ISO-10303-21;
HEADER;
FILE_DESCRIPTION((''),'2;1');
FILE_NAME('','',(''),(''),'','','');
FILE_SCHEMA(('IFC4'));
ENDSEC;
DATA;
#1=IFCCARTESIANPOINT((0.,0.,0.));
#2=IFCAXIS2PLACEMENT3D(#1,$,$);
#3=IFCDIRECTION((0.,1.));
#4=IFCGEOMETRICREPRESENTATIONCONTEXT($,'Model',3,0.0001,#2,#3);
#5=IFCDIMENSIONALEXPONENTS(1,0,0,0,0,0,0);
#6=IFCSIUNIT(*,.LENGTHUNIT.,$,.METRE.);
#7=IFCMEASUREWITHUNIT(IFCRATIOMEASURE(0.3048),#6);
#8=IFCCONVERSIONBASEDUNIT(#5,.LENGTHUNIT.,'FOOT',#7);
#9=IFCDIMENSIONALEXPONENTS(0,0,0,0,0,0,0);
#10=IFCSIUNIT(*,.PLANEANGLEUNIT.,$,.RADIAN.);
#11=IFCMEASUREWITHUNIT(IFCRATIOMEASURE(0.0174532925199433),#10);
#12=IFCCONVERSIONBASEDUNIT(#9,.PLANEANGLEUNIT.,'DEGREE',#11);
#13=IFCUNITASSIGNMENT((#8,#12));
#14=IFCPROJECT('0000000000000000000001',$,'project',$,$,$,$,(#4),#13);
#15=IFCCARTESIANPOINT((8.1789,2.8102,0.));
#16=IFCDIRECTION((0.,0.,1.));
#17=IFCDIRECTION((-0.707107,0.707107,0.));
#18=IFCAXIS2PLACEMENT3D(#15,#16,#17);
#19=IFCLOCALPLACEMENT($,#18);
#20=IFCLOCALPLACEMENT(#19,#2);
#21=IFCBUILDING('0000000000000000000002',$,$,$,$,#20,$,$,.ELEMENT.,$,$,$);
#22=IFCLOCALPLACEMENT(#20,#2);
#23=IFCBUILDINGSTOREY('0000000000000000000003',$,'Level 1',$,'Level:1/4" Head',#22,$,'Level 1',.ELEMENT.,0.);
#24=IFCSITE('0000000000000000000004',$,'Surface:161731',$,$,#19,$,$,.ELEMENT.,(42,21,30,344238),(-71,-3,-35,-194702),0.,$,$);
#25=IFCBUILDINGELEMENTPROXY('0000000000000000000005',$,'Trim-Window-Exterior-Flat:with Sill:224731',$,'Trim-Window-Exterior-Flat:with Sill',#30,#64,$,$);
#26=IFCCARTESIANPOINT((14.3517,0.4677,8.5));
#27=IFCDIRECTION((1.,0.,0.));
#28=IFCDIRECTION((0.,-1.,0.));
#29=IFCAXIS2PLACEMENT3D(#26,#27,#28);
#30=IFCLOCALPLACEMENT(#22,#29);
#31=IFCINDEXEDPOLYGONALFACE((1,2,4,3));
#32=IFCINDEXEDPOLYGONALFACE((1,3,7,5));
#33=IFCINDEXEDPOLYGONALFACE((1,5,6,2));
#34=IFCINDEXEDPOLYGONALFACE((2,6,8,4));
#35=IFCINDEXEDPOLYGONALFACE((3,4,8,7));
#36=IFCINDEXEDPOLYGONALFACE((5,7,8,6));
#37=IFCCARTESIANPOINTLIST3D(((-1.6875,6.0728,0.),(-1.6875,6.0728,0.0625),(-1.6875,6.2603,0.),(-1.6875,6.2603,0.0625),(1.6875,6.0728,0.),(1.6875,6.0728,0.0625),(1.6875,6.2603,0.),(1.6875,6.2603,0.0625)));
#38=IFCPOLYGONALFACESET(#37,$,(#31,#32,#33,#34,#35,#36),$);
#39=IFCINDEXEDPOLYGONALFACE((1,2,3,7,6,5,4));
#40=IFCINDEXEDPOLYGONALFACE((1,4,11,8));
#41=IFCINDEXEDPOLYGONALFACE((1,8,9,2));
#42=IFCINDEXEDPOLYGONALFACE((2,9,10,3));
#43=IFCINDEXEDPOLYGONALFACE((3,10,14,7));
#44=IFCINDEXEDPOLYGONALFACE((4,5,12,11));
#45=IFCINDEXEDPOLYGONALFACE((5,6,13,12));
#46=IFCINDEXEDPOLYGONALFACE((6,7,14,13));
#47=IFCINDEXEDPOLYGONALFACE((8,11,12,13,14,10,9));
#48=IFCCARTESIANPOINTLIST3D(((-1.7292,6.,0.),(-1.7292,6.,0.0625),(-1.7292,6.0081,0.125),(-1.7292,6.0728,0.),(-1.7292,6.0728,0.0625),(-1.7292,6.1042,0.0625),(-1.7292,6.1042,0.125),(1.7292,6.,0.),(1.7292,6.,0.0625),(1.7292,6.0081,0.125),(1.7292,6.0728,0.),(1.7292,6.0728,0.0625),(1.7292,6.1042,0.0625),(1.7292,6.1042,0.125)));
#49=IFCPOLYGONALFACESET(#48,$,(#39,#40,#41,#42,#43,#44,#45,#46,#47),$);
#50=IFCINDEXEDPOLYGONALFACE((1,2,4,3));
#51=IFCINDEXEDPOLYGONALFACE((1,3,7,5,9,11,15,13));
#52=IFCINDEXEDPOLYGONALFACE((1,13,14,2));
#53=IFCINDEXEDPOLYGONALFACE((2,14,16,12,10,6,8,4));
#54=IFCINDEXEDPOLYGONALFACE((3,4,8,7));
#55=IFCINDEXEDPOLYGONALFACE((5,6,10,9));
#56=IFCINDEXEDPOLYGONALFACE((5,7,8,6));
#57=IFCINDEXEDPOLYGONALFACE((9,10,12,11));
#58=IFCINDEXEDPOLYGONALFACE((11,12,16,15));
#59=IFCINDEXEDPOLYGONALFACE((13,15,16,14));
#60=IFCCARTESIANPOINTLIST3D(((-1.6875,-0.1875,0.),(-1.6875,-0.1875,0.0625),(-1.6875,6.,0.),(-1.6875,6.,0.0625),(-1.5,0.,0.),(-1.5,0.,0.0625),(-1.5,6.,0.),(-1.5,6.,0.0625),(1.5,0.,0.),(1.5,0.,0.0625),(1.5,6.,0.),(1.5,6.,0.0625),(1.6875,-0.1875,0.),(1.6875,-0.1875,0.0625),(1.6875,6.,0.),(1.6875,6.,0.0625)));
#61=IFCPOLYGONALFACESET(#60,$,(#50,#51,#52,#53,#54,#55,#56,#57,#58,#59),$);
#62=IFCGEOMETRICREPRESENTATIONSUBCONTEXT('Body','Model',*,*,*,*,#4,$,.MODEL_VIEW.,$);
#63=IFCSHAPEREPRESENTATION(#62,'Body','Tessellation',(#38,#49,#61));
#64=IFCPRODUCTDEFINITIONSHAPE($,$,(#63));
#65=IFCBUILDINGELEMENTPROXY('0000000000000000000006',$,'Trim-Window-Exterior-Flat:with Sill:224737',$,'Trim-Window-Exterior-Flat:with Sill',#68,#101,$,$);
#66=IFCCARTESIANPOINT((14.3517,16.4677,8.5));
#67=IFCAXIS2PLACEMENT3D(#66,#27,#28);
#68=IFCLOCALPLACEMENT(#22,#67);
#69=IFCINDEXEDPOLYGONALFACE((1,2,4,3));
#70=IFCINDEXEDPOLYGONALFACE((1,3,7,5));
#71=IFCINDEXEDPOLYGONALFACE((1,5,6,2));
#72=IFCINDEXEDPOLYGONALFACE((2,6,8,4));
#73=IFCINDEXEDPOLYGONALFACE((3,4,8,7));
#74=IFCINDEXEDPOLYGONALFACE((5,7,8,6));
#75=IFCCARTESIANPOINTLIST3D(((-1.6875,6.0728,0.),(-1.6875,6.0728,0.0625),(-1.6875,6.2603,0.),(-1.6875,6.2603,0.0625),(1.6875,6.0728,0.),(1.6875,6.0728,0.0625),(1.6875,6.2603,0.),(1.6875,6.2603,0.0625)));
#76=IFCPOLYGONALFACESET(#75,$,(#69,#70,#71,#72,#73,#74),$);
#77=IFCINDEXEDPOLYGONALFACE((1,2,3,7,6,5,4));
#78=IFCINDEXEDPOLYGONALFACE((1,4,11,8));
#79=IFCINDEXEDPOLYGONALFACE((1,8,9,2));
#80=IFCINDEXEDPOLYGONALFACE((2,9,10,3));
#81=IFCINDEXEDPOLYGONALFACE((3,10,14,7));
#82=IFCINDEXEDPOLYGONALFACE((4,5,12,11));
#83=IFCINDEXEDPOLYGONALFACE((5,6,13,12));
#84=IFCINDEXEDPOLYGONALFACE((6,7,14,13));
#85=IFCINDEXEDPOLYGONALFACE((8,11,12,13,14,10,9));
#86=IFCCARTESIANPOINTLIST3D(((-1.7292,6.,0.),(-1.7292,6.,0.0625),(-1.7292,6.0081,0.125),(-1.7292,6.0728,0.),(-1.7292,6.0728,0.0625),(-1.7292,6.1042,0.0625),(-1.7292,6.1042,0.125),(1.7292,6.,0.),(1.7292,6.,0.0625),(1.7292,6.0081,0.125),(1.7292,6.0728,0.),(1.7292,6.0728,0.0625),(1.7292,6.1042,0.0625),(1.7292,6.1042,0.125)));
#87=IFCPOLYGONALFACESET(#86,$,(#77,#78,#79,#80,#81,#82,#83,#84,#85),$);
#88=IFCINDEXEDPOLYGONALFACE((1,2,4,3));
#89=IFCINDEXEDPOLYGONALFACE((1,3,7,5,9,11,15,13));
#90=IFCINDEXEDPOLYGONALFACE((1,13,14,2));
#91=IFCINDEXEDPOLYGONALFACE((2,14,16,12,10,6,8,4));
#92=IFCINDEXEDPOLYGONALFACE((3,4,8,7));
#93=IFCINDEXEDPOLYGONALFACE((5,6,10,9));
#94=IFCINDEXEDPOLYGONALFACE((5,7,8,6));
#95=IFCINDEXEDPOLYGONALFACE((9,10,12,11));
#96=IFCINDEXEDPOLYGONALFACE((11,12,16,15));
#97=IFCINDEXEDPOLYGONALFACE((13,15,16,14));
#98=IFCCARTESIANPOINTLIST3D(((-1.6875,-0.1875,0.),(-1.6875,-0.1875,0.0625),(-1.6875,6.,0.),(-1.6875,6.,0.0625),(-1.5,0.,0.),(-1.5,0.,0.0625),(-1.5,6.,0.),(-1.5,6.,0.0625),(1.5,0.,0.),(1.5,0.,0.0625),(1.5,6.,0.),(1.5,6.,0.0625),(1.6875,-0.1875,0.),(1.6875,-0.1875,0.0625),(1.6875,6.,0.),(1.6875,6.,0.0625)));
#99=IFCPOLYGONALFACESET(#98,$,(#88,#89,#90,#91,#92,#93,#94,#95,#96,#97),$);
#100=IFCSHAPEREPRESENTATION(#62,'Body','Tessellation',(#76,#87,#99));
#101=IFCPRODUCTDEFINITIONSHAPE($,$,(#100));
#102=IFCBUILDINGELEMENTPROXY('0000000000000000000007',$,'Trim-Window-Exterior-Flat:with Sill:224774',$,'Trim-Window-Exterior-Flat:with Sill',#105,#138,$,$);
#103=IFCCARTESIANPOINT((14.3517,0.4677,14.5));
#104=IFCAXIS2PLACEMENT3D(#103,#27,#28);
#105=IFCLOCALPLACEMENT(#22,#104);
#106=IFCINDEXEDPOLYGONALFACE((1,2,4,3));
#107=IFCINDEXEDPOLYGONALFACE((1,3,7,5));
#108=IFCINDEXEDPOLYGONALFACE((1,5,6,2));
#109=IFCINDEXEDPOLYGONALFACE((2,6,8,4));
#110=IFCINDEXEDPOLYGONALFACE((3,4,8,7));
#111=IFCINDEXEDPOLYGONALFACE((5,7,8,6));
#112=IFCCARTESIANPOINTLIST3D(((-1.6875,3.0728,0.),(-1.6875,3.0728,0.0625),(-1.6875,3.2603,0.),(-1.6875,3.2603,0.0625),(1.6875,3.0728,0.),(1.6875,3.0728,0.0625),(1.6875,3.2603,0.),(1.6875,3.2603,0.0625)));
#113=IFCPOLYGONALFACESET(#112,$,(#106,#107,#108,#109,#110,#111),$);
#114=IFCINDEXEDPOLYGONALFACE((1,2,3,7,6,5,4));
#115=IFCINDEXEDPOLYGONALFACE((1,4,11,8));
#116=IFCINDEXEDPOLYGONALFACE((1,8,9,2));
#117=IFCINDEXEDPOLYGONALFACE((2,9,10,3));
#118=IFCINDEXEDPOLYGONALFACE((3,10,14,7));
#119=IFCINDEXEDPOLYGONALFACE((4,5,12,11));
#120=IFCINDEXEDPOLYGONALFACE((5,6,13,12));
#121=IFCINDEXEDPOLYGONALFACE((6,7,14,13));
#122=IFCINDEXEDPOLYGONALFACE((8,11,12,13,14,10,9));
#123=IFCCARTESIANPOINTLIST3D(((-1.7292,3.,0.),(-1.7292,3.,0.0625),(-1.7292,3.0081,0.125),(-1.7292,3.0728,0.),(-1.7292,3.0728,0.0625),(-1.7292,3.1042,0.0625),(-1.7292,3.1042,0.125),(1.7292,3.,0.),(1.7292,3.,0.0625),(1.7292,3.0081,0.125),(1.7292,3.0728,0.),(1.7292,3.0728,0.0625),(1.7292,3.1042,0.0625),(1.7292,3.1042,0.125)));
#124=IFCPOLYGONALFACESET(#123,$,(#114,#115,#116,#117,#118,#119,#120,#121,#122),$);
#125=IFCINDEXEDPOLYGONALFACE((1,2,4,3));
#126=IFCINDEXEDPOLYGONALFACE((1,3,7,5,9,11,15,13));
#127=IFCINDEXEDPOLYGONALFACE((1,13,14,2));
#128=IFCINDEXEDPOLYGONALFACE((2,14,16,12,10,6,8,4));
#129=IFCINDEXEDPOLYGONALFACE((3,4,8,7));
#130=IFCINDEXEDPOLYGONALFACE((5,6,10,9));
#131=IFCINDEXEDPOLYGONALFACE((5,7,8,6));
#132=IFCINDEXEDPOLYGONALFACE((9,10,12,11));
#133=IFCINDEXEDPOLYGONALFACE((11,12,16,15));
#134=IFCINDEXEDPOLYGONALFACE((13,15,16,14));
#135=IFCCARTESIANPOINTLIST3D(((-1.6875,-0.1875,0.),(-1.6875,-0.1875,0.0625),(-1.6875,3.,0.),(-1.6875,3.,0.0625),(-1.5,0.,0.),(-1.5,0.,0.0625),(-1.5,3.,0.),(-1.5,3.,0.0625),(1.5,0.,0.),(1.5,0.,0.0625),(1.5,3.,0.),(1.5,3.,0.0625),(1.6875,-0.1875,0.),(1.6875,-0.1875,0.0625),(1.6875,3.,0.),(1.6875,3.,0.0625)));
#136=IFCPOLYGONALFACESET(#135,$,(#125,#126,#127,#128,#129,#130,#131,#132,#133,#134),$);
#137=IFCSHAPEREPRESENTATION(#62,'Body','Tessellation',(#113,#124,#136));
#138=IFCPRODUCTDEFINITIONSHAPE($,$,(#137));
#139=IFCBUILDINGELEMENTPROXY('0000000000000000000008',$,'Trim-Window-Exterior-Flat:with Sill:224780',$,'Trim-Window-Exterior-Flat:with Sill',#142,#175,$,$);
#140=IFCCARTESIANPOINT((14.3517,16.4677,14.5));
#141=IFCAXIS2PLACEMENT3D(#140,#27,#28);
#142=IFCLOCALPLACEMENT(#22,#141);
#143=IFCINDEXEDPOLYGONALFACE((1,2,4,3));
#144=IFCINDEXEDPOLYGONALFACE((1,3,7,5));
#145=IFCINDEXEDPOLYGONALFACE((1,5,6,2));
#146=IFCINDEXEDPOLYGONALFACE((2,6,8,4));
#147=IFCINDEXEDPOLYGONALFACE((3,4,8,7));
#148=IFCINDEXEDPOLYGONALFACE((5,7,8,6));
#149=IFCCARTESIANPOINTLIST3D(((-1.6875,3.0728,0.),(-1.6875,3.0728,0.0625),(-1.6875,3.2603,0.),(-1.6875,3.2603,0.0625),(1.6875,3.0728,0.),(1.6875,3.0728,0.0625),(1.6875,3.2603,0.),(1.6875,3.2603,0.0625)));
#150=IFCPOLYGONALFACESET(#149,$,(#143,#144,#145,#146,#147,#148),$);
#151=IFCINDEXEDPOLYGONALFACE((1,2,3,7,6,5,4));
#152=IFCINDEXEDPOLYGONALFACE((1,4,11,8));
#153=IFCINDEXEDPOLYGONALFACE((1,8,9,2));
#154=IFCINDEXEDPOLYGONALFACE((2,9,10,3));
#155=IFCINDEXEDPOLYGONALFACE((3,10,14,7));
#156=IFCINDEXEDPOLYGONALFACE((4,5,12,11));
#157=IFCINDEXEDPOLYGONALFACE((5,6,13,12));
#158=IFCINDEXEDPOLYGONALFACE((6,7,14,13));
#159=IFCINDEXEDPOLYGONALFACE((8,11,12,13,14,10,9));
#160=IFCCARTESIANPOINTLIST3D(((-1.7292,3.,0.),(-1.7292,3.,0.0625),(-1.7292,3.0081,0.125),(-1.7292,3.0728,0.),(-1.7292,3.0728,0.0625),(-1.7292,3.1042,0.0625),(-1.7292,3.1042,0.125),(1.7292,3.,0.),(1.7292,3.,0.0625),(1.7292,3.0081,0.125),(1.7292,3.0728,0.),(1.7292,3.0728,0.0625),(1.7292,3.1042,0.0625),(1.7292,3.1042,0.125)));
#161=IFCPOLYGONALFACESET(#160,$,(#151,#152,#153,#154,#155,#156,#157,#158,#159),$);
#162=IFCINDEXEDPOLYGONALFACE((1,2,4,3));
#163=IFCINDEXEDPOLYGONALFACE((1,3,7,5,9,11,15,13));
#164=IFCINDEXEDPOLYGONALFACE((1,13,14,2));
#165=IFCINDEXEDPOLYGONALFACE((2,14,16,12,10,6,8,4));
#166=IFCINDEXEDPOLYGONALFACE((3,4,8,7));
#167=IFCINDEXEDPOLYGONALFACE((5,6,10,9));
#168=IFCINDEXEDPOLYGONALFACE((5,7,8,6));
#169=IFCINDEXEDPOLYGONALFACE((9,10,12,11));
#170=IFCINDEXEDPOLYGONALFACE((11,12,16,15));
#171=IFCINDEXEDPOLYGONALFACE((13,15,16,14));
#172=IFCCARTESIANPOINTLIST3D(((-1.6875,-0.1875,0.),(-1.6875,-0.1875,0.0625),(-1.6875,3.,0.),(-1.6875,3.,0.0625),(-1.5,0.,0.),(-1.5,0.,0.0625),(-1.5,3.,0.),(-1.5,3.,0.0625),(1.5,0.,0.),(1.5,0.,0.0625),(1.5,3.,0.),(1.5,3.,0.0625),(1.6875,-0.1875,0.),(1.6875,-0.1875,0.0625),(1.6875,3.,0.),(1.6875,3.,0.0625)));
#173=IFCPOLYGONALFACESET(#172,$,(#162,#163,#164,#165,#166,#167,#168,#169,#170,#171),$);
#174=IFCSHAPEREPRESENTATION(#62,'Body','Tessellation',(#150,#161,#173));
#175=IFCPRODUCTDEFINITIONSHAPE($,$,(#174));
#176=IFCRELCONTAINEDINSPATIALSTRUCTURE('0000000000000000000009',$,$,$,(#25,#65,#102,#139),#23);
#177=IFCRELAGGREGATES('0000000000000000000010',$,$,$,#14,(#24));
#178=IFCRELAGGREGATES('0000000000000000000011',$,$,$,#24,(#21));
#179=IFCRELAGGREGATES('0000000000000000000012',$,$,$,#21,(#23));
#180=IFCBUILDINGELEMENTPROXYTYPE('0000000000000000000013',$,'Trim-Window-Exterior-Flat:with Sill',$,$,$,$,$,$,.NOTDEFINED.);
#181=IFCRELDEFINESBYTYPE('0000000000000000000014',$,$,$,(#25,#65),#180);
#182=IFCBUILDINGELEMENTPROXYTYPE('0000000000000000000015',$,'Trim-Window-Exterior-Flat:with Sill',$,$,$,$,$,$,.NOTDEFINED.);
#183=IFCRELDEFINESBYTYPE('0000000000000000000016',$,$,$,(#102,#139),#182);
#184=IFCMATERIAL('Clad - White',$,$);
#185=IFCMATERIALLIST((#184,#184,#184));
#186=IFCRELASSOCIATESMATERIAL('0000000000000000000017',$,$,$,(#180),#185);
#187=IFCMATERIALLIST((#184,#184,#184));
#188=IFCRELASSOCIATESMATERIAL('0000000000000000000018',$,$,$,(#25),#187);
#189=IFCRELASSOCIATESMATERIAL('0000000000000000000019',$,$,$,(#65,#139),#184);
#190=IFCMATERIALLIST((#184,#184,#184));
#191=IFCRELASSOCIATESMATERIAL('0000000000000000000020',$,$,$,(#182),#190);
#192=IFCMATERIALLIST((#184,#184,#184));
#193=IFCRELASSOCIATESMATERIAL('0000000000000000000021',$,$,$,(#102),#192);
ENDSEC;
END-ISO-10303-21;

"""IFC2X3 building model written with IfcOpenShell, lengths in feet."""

from ifc_helpers import new_model, entity, si_unit, converted_unit, direction, frame, frame_2d, origin, origin_2d_with_axis, place, context, subcontext, project, spatial, polyline, rectangle, outline, extrude, source, transform, mapped, material, material_list, type_object, type_shapes, element, save


model = new_model("IFC2X3")

# Units and contexts
model_context = context("Model", 3, precision=0.0001, world=origin(), true_north=direction((0.0, 1.0)))
body_context = subcontext(model_context, "Body", "Model", "MODEL_VIEW")
ifc_project = project(units=[converted_unit("LENGTHUNIT", "FOOT", entity("IfcRatioMeasure", 0.3048), si_unit("LENGTHUNIT", "METRE"), dimensions=[1, 0, 0, 0, 0, 0, 0]), converted_unit("PLANEANGLEUNIT", "DEGREE", entity("IfcRatioMeasure", 0.0174532925199433), si_unit("PLANEANGLEUNIT", "RADIAN"), dimensions=[0, 0, 0, 0, 0, 0, 0])], contexts=[model_context])

# Site, building, storey
site_placement = place(None, frame((8.1789, 2.8102, 0.0), z_axis=(0.0, 0.0, 1.0), x_axis=(-0.707107, 0.707107, 0.0)))
site = spatial("IfcSite", under=ifc_project, at=site_placement, Name="Surface:161731", CompositionType="ELEMENT", RefLatitude=(42, 21, 30, 344238), RefLongitude=(-71, -3, -35, -194702), RefElevation=0.0)
building_placement = place(site_placement, origin())
building = spatial("IfcBuilding", under=site, at=building_placement, CompositionType="ELEMENT")
storey_placement = place(building_placement, origin())
storey = spatial("IfcBuildingStorey", under=building, at=storey_placement, Name="Level 1", ObjectType="Level:1/4\" Head", LongName="Level 1", CompositionType="ELEMENT", Elevation=0.0)

# Building element proxies
ifc_material_1 = material(Name="Clad - White")
ifc_material_list_1 = material_list([ifc_material_1, ifc_material_1, ifc_material_1])
ifc_material_list_2 = material_list([ifc_material_1, ifc_material_1, ifc_material_1])
building_element_proxy_type_1 = type_object("IfcBuildingElementProxyType", Name="Trim-Window-Exterior-Flat:with Sill", PredefinedType="NOTDEFINED", material=ifc_material_list_2)
shared_shape_1 = source(origin(), body_context, "Body", "SweptSolid", [
    extrude(rectangle(XDim=0.1875, YDim=3.375, at=origin_2d_with_axis()), frame((0.0, 6.1665, 0.0), z_axis=(0.0, 0.0, 1.0), x_axis=(0.0, 1.0, 0.0)), (0.0, 0.0, 1.0), 0.0625),
    extrude(outline(polyline([(-0.0525, -0.0625), (0.0436, -0.0625), (0.0517, 0.0), (0.0517, 0.0625), (-0.0211, 0.0625), (-0.0211, 0.0), (-0.0525, 0.0), (-0.0525, -0.0625)])), frame((-1.7292, 6.0517, 0.0625), z_axis=(1.0, 0.0, 0.0), x_axis=(0.0, -1.0, 0.0)), (0.0, 0.0, 1.0), 3.4583),
    extrude(outline(polyline([(-1.6875, -3.1406), (1.6875, -3.1406), (1.6875, 3.0469), (1.5, 3.0469), (1.5, -2.9531), (-1.5, -2.9531), (-1.5, 3.0469), (-1.6875, 3.0469), (-1.6875, -3.1406)])), frame((0.0, 2.9531, 0.0)), (0.0, 0.0, 1.0), 0.0625),
])
type_shapes(building_element_proxy_type_1, [shared_shape_1])
proxy_1_placement = place(storey_placement, frame((14.3517, 0.4677, 8.5), z_axis=(1.0, 0.0, 0.0), x_axis=(0.0, -1.0, 0.0)))
element("IfcBuildingElementProxy", 1, at=proxy_1_placement, inside=storey, type_object=building_element_proxy_type_1, material=ifc_material_list_1, Name="Trim-Window-Exterior-Flat:with Sill:224731", ObjectType="Trim-Window-Exterior-Flat:with Sill", context=body_context, shape_type="MappedRepresentation", body=[
    mapped(shared_shape_1, transform((0.0, 0.0, 0.0), scale=1.0)),
])
proxy_2_placement = place(storey_placement, frame((14.3517, 16.4677, 8.5), z_axis=(1.0, 0.0, 0.0), x_axis=(0.0, -1.0, 0.0)))
element("IfcBuildingElementProxy", 2, at=proxy_2_placement, inside=storey, type_object=building_element_proxy_type_1, material=ifc_material_1, Name="Trim-Window-Exterior-Flat:with Sill:224737", ObjectType="Trim-Window-Exterior-Flat:with Sill", context=body_context, shape_type="MappedRepresentation", body=[
    mapped(shared_shape_1, transform((0.0, 0.0, 0.0), scale=1.0)),
])
ifc_material_list_3 = material_list([ifc_material_1, ifc_material_1, ifc_material_1])
ifc_material_list_4 = material_list([ifc_material_1, ifc_material_1, ifc_material_1])
building_element_proxy_type_2 = type_object("IfcBuildingElementProxyType", Name="Trim-Window-Exterior-Flat:with Sill", PredefinedType="NOTDEFINED", material=ifc_material_list_4)
shared_shape_2 = source(origin(), body_context, "Body", "SweptSolid", [
    extrude(rectangle(XDim=0.1875, YDim=3.375, at=frame_2d((0.0, 0.0), x_axis=(1.0, 0.0))), frame((0.0, 3.1665, 0.0), z_axis=(0.0, 0.0, 1.0), x_axis=(0.0, 1.0, 0.0)), (0.0, 0.0, 1.0), 0.0625),
    extrude(outline(polyline([(-0.0525, -0.0625), (0.0436, -0.0625), (0.0517, 0.0), (0.0517, 0.0625), (-0.0211, 0.0625), (-0.0211, 0.0), (-0.0525, 0.0), (-0.0525, -0.0625)])), frame((-1.7292, 3.0517, 0.0625), z_axis=(1.0, 0.0, 0.0), x_axis=(0.0, -1.0, 0.0)), (0.0, 0.0, 1.0), 3.4583),
    extrude(outline(polyline([(-1.6875, -1.6406), (1.6875, -1.6406), (1.6875, 1.5469), (1.5, 1.5469), (1.5, -1.4531), (-1.5, -1.4531), (-1.5, 1.5469), (-1.6875, 1.5469), (-1.6875, -1.6406)])), frame((0.0, 1.4531, 0.0)), (0.0, 0.0, 1.0), 0.0625),
])
type_shapes(building_element_proxy_type_2, [shared_shape_2])
proxy_3_placement = place(storey_placement, frame((14.3517, 0.4677, 14.5), z_axis=(1.0, 0.0, 0.0), x_axis=(0.0, -1.0, 0.0)))
element("IfcBuildingElementProxy", 3, at=proxy_3_placement, inside=storey, type_object=building_element_proxy_type_2, material=ifc_material_list_3, Name="Trim-Window-Exterior-Flat:with Sill:224774", ObjectType="Trim-Window-Exterior-Flat:with Sill", context=body_context, shape_type="MappedRepresentation", body=[
    mapped(shared_shape_2, transform((0.0, 0.0, 0.0), scale=1.0)),
])
proxy_4_placement = place(storey_placement, frame((14.3517, 16.4677, 14.5), z_axis=(1.0, 0.0, 0.0), x_axis=(0.0, -1.0, 0.0)))
element("IfcBuildingElementProxy", 4, at=proxy_4_placement, inside=storey, type_object=building_element_proxy_type_2, material=ifc_material_1, Name="Trim-Window-Exterior-Flat:with Sill:224780", ObjectType="Trim-Window-Exterior-Flat:with Sill", context=body_context, shape_type="MappedRepresentation", body=[
    mapped(shared_shape_2, transform((0.0, 0.0, 0.0), scale=1.0)),
])

save(model, "model.ifc")
